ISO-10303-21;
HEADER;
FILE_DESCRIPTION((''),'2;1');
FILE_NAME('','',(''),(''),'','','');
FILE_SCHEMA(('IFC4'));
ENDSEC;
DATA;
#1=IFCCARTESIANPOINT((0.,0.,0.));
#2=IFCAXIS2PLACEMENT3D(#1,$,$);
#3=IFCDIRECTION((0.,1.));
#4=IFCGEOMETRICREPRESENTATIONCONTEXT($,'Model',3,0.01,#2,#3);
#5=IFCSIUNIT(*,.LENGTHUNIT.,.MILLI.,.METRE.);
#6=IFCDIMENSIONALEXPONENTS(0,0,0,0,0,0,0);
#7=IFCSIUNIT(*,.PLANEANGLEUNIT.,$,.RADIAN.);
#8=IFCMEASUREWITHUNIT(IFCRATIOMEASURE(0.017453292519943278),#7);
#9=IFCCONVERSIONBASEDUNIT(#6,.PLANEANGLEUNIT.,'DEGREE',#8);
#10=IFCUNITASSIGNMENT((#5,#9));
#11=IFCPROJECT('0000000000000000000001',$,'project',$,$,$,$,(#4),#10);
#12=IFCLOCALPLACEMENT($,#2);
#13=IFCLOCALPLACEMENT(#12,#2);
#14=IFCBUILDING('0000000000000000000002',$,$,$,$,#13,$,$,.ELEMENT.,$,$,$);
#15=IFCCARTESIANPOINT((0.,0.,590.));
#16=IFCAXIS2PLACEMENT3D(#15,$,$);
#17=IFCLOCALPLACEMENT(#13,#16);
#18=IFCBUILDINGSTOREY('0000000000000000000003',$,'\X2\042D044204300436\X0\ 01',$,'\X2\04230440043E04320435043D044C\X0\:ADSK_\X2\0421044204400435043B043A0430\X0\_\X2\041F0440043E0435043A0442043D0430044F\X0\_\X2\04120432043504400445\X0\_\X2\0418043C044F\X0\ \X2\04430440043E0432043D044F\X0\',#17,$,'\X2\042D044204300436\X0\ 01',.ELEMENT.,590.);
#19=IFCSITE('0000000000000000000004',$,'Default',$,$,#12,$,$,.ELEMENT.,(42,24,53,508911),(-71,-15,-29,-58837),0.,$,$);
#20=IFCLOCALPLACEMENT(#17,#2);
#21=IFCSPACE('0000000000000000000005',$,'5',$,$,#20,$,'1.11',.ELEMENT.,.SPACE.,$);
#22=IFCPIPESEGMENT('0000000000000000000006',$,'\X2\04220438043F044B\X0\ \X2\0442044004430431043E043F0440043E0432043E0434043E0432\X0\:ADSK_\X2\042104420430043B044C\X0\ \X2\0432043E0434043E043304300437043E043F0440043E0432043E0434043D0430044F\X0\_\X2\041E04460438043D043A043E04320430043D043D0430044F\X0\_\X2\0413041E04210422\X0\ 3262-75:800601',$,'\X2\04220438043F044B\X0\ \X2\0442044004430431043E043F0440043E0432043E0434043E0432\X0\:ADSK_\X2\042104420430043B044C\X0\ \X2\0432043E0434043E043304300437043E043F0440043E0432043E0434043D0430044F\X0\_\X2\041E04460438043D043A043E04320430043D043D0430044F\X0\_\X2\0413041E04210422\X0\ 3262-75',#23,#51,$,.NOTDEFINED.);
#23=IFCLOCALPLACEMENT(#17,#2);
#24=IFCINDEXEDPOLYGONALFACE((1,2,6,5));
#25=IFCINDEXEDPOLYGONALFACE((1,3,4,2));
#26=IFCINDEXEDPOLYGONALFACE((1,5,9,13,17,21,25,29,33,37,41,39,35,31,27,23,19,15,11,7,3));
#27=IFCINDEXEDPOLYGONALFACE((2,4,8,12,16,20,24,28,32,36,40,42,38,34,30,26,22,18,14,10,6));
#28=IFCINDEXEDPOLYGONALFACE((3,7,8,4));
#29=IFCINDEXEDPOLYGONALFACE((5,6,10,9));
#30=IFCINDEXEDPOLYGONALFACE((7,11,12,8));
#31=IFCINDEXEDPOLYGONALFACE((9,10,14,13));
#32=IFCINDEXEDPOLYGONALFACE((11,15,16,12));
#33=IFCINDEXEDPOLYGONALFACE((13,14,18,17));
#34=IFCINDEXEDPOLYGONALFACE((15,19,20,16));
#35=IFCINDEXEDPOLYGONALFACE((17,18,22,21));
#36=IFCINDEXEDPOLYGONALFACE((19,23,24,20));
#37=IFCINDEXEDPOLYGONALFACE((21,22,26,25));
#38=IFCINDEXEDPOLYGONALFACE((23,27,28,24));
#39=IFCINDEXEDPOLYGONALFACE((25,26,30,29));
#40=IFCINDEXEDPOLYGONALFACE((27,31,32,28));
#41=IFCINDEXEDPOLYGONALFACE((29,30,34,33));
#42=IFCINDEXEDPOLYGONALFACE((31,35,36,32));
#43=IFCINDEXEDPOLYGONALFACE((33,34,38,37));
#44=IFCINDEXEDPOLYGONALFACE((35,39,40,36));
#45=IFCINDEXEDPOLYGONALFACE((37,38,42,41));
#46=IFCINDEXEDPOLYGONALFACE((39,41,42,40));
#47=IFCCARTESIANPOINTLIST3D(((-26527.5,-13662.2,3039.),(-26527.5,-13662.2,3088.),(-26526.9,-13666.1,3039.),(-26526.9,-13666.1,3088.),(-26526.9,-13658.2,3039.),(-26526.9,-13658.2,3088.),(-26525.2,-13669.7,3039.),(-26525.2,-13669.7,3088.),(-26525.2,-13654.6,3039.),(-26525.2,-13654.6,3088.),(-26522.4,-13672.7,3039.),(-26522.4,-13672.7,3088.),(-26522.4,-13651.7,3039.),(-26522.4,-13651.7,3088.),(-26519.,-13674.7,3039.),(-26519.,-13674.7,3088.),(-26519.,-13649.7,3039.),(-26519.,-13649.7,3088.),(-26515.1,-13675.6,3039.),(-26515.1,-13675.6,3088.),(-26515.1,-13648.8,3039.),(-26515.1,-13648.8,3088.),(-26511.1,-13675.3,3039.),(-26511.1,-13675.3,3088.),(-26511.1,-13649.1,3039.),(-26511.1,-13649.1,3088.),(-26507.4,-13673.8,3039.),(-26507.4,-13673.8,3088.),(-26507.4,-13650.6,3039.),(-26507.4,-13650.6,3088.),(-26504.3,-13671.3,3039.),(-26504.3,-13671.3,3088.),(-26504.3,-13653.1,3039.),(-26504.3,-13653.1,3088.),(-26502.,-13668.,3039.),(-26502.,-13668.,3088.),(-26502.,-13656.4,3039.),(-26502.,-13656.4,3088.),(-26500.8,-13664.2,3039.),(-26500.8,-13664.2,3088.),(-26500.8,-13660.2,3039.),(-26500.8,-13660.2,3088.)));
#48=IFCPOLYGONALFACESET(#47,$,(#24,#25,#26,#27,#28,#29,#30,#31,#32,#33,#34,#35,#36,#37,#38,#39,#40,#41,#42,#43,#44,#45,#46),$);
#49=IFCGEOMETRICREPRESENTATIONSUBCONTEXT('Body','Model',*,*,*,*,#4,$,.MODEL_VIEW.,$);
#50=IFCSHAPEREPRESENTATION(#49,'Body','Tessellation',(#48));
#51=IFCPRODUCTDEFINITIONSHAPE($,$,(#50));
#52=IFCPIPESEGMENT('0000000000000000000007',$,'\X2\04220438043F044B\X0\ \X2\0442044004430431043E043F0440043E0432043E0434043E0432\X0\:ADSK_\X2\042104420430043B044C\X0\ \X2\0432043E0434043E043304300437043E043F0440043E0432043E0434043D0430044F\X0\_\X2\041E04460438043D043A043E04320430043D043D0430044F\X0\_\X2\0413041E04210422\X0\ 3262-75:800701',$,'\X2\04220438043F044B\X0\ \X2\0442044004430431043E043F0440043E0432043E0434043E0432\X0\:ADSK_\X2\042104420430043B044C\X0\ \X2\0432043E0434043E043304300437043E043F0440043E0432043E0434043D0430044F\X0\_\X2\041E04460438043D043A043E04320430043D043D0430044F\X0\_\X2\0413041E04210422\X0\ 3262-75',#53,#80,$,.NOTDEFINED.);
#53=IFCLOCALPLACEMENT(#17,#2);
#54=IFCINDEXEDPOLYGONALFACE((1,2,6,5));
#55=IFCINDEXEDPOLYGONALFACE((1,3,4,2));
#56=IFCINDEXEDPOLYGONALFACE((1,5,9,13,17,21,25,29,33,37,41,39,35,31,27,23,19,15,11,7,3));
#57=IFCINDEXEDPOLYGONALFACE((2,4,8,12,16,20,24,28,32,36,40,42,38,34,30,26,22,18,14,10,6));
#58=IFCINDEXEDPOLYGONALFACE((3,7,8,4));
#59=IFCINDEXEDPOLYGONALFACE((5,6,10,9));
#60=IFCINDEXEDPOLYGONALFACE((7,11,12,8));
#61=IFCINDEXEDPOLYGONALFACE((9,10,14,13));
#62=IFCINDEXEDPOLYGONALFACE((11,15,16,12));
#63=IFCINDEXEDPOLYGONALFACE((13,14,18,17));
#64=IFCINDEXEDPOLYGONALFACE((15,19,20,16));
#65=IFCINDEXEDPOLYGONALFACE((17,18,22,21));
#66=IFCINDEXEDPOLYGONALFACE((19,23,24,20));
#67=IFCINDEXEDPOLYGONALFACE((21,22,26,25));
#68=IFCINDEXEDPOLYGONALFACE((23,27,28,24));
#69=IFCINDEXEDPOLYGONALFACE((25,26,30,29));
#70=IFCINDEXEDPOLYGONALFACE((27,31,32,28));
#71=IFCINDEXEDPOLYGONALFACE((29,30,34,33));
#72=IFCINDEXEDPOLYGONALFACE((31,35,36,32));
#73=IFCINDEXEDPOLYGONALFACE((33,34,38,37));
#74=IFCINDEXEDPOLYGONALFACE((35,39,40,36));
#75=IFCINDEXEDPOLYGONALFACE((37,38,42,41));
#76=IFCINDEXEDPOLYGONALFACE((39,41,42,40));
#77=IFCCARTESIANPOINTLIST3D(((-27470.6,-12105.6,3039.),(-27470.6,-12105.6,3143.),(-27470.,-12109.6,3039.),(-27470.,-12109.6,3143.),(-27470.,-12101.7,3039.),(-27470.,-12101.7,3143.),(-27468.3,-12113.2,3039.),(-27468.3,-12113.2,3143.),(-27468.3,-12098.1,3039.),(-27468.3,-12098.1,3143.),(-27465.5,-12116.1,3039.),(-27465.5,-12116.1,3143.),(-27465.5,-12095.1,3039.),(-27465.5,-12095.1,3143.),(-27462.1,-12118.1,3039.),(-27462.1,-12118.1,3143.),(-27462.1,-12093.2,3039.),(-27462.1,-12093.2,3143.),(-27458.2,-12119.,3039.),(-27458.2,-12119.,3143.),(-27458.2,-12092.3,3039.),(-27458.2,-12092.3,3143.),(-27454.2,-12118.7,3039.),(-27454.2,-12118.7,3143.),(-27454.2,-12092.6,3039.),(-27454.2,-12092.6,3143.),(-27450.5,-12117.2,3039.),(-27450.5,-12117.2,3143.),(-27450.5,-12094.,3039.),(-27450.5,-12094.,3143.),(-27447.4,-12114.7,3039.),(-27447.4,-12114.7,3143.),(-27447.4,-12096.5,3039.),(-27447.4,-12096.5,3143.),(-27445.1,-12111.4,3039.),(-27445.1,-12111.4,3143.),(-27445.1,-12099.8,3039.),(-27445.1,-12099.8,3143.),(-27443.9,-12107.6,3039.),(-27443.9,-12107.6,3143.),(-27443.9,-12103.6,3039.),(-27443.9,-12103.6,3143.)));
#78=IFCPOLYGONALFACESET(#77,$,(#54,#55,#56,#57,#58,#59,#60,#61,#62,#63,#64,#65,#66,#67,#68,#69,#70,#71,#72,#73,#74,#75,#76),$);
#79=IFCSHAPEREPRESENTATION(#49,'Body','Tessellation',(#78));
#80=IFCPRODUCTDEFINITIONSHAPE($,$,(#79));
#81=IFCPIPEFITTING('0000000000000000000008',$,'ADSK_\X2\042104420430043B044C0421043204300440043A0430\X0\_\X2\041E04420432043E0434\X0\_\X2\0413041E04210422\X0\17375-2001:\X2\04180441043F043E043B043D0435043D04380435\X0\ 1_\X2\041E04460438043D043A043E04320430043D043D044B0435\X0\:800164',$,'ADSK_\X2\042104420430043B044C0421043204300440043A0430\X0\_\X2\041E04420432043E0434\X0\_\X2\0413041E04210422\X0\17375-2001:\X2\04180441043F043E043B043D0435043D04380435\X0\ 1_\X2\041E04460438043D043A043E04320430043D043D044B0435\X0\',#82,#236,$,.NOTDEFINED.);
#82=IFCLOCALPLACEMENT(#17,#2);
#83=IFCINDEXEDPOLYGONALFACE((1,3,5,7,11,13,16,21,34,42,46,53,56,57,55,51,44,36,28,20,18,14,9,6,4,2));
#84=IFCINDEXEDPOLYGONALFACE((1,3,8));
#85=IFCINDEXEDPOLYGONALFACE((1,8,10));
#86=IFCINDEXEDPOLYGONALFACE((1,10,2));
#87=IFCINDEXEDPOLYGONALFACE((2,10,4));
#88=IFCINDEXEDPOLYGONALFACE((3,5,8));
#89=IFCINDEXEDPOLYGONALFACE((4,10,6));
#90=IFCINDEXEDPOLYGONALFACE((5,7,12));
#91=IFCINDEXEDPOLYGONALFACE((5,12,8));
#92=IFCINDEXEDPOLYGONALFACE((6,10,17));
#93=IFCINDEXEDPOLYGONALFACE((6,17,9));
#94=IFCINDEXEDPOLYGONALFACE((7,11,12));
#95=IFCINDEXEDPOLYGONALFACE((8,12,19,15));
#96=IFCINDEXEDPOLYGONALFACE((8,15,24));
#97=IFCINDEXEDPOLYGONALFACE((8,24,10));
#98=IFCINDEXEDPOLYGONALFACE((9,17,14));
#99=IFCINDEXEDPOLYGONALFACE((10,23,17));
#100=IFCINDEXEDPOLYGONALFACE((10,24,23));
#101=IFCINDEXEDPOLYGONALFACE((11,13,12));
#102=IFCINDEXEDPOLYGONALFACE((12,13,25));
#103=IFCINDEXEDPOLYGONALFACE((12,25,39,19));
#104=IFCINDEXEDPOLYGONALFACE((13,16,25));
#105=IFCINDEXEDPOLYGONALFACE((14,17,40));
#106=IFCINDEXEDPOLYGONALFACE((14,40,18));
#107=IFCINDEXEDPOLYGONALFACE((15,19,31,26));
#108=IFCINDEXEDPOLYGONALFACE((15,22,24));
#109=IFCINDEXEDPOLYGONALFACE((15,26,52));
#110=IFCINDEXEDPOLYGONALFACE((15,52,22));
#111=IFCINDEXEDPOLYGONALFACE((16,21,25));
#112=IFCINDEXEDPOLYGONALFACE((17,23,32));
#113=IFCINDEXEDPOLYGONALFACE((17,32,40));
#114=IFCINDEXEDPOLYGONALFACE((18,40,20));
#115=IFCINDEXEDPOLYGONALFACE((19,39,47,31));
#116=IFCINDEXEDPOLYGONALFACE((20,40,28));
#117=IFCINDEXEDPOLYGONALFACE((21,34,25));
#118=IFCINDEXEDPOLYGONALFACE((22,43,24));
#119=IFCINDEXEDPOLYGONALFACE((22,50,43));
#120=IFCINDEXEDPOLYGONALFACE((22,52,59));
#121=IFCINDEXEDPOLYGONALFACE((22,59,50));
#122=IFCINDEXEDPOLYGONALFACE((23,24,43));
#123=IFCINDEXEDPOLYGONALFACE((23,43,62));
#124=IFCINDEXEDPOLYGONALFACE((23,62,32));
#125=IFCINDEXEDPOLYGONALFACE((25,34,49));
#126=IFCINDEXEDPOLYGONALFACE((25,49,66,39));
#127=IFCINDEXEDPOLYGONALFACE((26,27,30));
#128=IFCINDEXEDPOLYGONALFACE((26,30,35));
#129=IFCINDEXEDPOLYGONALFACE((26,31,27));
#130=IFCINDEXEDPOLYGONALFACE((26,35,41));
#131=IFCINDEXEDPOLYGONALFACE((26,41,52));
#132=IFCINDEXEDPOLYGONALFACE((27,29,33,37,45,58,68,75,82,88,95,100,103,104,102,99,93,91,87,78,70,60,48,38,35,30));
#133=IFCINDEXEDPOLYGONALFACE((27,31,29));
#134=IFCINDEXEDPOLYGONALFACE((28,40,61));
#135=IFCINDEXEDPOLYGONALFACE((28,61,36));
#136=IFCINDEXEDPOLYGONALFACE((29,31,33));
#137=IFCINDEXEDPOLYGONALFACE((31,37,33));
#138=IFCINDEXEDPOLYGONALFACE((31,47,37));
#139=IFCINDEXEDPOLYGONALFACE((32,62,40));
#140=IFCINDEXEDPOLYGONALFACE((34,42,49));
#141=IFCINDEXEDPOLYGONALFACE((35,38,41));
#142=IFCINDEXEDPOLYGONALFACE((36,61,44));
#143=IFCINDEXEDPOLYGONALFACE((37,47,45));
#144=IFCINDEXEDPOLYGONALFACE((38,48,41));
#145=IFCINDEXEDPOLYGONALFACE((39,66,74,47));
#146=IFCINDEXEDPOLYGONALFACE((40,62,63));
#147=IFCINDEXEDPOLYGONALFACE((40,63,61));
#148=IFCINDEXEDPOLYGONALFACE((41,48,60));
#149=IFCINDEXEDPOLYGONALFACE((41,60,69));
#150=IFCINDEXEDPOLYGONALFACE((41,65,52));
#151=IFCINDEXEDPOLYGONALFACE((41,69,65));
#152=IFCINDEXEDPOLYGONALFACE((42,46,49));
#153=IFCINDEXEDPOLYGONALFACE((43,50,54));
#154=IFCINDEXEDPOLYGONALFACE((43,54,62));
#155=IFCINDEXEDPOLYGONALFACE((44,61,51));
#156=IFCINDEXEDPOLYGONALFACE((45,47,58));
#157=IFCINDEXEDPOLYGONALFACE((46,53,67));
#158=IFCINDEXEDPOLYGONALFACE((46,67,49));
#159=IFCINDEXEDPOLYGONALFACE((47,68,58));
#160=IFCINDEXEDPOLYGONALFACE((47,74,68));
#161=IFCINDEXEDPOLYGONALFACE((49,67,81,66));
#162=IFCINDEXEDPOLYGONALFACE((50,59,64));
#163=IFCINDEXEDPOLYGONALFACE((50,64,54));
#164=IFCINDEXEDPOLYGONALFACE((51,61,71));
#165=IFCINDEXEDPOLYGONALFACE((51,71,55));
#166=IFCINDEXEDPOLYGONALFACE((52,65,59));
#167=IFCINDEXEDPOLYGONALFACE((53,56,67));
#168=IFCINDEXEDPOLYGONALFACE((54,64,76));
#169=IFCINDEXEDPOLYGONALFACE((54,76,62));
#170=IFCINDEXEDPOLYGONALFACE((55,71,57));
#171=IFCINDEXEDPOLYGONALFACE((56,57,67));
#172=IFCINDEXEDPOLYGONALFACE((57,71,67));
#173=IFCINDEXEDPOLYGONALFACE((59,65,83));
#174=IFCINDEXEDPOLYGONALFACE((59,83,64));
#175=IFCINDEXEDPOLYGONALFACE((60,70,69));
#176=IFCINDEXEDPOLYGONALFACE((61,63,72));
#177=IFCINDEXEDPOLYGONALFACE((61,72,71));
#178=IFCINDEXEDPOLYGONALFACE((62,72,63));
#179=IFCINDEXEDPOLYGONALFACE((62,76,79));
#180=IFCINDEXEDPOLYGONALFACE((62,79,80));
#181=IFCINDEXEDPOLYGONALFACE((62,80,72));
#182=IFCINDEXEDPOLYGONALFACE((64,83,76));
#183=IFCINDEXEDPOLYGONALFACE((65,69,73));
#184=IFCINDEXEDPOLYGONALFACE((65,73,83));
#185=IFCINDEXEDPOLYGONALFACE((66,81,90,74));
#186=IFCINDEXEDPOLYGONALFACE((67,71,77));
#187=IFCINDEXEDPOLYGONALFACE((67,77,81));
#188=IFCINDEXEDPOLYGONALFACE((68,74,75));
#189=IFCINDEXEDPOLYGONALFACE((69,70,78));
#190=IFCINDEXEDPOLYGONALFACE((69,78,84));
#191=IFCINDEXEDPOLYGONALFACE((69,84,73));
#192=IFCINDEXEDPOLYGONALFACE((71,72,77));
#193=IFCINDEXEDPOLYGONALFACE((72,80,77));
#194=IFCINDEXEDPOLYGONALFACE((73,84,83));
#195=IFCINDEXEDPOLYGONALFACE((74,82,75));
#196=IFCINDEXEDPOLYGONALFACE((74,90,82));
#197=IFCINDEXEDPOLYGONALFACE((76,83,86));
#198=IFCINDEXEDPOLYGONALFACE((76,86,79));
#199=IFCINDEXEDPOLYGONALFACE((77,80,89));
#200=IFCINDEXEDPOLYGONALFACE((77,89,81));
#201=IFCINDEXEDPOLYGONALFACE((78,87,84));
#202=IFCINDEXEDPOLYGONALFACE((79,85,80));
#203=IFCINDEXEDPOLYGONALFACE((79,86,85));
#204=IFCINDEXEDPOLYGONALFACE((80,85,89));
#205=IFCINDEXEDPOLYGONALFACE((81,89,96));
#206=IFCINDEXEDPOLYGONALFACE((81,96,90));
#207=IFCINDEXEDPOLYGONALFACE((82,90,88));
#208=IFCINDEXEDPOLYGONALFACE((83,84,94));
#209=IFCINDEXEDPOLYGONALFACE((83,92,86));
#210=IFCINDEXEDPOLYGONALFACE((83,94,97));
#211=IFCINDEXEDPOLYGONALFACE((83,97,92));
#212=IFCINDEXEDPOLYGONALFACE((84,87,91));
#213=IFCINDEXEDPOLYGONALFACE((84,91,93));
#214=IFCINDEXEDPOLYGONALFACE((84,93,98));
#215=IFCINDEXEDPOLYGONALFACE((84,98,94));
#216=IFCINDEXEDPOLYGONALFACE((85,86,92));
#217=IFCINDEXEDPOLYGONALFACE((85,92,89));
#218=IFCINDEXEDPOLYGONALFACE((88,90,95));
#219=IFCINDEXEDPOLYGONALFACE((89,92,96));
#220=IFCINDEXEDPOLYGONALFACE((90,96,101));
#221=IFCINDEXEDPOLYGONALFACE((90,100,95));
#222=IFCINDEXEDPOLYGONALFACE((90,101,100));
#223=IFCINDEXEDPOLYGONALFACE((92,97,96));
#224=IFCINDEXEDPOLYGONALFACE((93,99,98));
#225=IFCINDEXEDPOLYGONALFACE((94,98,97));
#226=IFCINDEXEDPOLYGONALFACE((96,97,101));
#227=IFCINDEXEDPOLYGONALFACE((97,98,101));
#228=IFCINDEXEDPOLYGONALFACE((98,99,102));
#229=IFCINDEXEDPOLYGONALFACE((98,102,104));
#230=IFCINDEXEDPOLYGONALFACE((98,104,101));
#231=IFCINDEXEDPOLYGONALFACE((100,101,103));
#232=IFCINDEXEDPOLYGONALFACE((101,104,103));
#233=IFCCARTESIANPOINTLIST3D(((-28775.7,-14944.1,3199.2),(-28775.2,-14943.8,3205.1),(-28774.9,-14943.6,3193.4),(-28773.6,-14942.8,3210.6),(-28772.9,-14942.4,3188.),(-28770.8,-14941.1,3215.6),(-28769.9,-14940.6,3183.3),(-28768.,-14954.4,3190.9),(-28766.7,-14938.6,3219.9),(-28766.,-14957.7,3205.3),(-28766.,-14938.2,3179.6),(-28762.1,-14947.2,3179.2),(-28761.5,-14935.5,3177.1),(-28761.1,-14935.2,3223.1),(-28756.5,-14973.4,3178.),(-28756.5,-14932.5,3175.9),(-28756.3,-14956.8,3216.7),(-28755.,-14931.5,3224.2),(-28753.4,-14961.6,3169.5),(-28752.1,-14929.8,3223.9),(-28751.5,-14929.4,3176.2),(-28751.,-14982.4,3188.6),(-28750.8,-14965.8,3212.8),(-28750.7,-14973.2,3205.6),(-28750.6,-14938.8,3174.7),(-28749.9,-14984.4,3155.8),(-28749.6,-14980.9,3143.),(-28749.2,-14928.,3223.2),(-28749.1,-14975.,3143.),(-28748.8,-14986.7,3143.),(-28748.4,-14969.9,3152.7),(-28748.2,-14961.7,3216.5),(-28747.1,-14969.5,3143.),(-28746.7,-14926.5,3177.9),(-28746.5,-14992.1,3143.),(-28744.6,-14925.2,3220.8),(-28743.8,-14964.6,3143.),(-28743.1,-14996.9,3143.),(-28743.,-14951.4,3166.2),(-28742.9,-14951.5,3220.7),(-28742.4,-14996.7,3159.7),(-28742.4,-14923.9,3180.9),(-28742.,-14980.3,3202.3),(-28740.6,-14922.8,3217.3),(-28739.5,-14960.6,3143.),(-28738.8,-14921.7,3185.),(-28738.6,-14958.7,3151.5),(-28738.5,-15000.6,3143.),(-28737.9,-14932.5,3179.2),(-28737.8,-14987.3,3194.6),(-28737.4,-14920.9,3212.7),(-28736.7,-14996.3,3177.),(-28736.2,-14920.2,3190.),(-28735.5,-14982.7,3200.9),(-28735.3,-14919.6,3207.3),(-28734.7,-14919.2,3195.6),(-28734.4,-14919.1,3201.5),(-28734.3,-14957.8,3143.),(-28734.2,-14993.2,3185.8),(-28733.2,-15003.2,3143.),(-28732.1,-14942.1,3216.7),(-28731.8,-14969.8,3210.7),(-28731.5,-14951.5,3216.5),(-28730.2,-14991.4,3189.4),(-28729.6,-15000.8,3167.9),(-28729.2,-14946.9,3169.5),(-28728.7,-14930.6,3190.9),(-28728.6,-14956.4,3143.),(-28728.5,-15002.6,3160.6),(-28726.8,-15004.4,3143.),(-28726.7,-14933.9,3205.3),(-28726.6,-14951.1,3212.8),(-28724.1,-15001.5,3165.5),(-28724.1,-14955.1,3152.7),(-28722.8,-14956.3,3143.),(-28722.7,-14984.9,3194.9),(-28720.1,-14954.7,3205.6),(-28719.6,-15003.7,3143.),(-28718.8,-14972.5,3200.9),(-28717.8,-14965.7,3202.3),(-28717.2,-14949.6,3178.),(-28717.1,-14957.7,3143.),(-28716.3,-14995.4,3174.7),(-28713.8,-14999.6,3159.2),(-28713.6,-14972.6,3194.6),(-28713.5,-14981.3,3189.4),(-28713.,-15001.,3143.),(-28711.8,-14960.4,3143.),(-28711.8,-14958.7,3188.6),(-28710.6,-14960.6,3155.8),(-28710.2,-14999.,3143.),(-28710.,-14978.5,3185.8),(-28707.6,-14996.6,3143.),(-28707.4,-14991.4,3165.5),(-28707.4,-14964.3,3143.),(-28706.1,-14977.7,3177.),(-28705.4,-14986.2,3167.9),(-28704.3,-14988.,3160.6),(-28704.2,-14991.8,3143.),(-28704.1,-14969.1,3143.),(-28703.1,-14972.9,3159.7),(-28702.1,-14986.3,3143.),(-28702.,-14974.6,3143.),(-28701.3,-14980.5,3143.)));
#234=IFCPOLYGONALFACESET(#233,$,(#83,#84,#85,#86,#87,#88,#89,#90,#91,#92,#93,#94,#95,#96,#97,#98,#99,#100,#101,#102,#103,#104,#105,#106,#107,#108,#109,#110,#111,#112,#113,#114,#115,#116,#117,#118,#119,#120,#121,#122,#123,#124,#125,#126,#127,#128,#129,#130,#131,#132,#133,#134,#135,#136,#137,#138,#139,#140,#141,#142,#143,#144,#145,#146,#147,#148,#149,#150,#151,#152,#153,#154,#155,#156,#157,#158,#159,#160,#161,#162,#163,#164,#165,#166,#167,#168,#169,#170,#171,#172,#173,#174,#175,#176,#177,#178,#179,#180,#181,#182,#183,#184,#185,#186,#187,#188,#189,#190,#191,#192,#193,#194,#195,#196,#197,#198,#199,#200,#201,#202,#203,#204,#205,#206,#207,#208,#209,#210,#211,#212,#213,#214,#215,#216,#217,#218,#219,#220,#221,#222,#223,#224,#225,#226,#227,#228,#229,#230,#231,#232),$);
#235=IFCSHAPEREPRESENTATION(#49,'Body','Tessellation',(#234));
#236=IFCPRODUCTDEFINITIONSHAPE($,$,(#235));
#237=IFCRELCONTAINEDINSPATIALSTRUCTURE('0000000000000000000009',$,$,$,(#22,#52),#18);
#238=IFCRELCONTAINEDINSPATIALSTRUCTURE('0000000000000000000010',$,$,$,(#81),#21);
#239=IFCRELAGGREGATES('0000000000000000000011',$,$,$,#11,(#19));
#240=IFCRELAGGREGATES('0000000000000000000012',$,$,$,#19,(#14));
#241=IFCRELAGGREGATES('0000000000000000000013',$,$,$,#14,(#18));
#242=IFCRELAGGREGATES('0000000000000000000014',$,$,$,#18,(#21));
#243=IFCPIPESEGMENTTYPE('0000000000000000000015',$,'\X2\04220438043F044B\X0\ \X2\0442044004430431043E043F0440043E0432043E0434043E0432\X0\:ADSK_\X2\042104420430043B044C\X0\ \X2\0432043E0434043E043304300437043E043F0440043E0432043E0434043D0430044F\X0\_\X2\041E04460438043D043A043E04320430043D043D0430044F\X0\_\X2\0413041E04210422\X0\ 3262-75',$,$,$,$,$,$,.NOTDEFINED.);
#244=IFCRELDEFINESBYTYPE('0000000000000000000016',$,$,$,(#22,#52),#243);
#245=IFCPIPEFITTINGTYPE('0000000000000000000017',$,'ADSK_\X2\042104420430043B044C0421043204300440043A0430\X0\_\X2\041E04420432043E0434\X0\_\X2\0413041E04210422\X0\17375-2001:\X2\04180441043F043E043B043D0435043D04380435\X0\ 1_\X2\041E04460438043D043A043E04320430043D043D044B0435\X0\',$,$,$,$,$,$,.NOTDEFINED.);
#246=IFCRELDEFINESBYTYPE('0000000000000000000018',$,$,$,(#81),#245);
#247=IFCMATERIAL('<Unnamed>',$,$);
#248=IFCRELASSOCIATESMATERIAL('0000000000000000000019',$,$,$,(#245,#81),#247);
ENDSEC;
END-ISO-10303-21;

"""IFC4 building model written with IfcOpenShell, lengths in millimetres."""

from ifc_helpers import new_model, entity, si_unit, converted_unit, direction, frame, origin, origin_2d_with_axis, place, context, subcontext, project, spatial, circle, extrude, source, transform, mapped, material, type_object, type_shapes, element, save


model = new_model("IFC4")

# Units and contexts
model_context = context("Model", 3, precision=0.01, world=origin(), true_north=direction((0.0, 1.0)))
body_context = subcontext(model_context, "Body", "Model", "MODEL_VIEW")
ifc_project = project(units=[si_unit("LENGTHUNIT", "METRE", prefix="MILLI"), converted_unit("PLANEANGLEUNIT", "DEGREE", entity("IfcRatioMeasure", 0.017453292519943278), si_unit("PLANEANGLEUNIT", "RADIAN"), dimensions=[0, 0, 0, 0, 0, 0, 0])], contexts=[model_context])

# Site, building, storey
site_placement = place(None, origin())
site = spatial("IfcSite", under=ifc_project, at=site_placement, Name="Default", CompositionType="ELEMENT", RefLatitude=(42, 24, 53, 508911), RefLongitude=(-71, -15, -29, -58837), RefElevation=0.0)
building_placement = place(site_placement, origin())
building = spatial("IfcBuilding", under=site, at=building_placement, CompositionType="ELEMENT")
storey_placement = place(building_placement, frame((0.0, 0.0, 590.0)))
storey = spatial("IfcBuildingStorey", under=building, at=storey_placement, Name="Этаж 01", ObjectType="Уровень:ADSK_Стрелка_Проектная_Вверх_Имя уровня", LongName="Этаж 01", CompositionType="ELEMENT", Elevation=590.0)

# Shared definitions
ifc_material_1 = material(Name="<Unnamed>")

# Pipe segments
pipe_segment_type = type_object("IfcPipeSegmentType", Name="Типы трубопроводов:ADSK_Сталь водогазопроводная_Оцинкованная_ГОСТ 3262-75", PredefinedType="NOTDEFINED")
pipe_segment_1_placement = place(storey_placement, frame((-26529.1, -13677.2, 3088.0)))
element("IfcPipeSegment", 1, at=pipe_segment_1_placement, inside=storey, type_object=pipe_segment_type, Name="Типы трубопроводов:ADSK_Сталь водогазопроводная_Оцинкованная_ГОСТ 3262-75:800601", ObjectType="Типы трубопроводов:ADSK_Сталь водогазопроводная_Оцинкованная_ГОСТ 3262-75", PredefinedType="NOTDEFINED", context=body_context, shape_type="SweptSolid", body=[
    extrude(circle(Radius=13.4, at=origin_2d_with_axis()), frame((15.0, 15.0, -49.0), z_axis=(0.0, 0.0, 1.0), x_axis=(-1.0, 0.0, 0.0)), (0.0, 0.0, 1.0), 49.0),
])
pipe_segment_2_placement = place(storey_placement, frame((-27472.2, -12120.6, 3143.0)))
element("IfcPipeSegment", 2, at=pipe_segment_2_placement, inside=storey, type_object=pipe_segment_type, Name="Типы трубопроводов:ADSK_Сталь водогазопроводная_Оцинкованная_ГОСТ 3262-75:800701", ObjectType="Типы трубопроводов:ADSK_Сталь водогазопроводная_Оцинкованная_ГОСТ 3262-75", PredefinedType="NOTDEFINED", context=body_context, shape_type="SweptSolid", body=[
    extrude(circle(Radius=13.4, at=origin_2d_with_axis()), frame((15.0, 15.0, -104.0), z_axis=(0.0, 0.0, 1.0), x_axis=(-1.0, 0.0, 0.0)), (0.0, 0.0, 1.0), 104.0),
])

# Shared definitions
space_1_placement = place(storey_placement, origin())
space_1 = spatial("IfcSpace", under=storey, at=space_1_placement, Name="5", LongName="1.11", CompositionType="ELEMENT", PredefinedType="SPACE")

# Pipe fitting
pipe_fitting_type = type_object("IfcPipeFittingType", Name="ADSK_СтальСварка_Отвод_ГОСТ17375-2001:Исполнение 1_Оцинкованные", PredefinedType="NOTDEFINED", material=ifc_material_1)
ifc_direction = entity("IfcDirection", [0.0, 0.0, 1.0])
trimmed_curve = entity("IfcTrimmedCurve", entity("IfcCircle", entity("IfcAxis2Placement2D", entity("IfcCartesianPoint", [-57.0, 0.0]), entity("IfcDirection", [0.0, 1.0])), 57.0), [entity("IfcParameterValue", 270.0)], [entity("IfcParameterValue", 0.0)], True, "PARAMETER")
shared_shape_1 = source(origin(), body_context, "Body", "AdvancedSweptSolid", [
    entity("IfcSurfaceCurveSweptAreaSolid", entity("IfcCircleProfileDef", "AREA", None, entity("IfcAxis2Placement2D", entity("IfcCartesianPoint", [0.0, 0.0]), entity("IfcDirection", [1.0, 0.0])), 24.1), entity("IfcAxis2Placement3D", entity("IfcCartesianPoint", [-57.0, 0.0, 0.0]), ifc_direction, entity("IfcDirection", [0.0, -1.0, 0.0])), trimmed_curve, 0.0, 90.0, entity("IfcSurfaceOfLinearExtrusion", entity("IfcArbitraryOpenProfileDef", "CURVE", None, trimmed_curve), entity("IfcAxis2Placement3D", entity("IfcCartesianPoint", [0.0, 0.0, -304.8])), ifc_direction, 1.0)),
])
type_shapes(pipe_fitting_type, [shared_shape_1])
pipe_fitting_placement = place(space_1_placement, frame((-28725.5, -14980.3, 3200.0), z_axis=(0.855267, 0.518188, 0.0), x_axis=(0.518188, -0.855267, 0.0)))
element("IfcPipeFitting", 3, at=pipe_fitting_placement, inside=space_1, type_object=pipe_fitting_type, material=ifc_material_1, Name="ADSK_СтальСварка_Отвод_ГОСТ17375-2001:Исполнение 1_Оцинкованные:800164", ObjectType="ADSK_СтальСварка_Отвод_ГОСТ17375-2001:Исполнение 1_Оцинкованные", PredefinedType="NOTDEFINED", context=body_context, shape_type="MappedRepresentation", body=[
    mapped(shared_shape_1, transform((0.0, 0.0, 0.0), scale=1.0)),
])

save(model, "model.ifc")
